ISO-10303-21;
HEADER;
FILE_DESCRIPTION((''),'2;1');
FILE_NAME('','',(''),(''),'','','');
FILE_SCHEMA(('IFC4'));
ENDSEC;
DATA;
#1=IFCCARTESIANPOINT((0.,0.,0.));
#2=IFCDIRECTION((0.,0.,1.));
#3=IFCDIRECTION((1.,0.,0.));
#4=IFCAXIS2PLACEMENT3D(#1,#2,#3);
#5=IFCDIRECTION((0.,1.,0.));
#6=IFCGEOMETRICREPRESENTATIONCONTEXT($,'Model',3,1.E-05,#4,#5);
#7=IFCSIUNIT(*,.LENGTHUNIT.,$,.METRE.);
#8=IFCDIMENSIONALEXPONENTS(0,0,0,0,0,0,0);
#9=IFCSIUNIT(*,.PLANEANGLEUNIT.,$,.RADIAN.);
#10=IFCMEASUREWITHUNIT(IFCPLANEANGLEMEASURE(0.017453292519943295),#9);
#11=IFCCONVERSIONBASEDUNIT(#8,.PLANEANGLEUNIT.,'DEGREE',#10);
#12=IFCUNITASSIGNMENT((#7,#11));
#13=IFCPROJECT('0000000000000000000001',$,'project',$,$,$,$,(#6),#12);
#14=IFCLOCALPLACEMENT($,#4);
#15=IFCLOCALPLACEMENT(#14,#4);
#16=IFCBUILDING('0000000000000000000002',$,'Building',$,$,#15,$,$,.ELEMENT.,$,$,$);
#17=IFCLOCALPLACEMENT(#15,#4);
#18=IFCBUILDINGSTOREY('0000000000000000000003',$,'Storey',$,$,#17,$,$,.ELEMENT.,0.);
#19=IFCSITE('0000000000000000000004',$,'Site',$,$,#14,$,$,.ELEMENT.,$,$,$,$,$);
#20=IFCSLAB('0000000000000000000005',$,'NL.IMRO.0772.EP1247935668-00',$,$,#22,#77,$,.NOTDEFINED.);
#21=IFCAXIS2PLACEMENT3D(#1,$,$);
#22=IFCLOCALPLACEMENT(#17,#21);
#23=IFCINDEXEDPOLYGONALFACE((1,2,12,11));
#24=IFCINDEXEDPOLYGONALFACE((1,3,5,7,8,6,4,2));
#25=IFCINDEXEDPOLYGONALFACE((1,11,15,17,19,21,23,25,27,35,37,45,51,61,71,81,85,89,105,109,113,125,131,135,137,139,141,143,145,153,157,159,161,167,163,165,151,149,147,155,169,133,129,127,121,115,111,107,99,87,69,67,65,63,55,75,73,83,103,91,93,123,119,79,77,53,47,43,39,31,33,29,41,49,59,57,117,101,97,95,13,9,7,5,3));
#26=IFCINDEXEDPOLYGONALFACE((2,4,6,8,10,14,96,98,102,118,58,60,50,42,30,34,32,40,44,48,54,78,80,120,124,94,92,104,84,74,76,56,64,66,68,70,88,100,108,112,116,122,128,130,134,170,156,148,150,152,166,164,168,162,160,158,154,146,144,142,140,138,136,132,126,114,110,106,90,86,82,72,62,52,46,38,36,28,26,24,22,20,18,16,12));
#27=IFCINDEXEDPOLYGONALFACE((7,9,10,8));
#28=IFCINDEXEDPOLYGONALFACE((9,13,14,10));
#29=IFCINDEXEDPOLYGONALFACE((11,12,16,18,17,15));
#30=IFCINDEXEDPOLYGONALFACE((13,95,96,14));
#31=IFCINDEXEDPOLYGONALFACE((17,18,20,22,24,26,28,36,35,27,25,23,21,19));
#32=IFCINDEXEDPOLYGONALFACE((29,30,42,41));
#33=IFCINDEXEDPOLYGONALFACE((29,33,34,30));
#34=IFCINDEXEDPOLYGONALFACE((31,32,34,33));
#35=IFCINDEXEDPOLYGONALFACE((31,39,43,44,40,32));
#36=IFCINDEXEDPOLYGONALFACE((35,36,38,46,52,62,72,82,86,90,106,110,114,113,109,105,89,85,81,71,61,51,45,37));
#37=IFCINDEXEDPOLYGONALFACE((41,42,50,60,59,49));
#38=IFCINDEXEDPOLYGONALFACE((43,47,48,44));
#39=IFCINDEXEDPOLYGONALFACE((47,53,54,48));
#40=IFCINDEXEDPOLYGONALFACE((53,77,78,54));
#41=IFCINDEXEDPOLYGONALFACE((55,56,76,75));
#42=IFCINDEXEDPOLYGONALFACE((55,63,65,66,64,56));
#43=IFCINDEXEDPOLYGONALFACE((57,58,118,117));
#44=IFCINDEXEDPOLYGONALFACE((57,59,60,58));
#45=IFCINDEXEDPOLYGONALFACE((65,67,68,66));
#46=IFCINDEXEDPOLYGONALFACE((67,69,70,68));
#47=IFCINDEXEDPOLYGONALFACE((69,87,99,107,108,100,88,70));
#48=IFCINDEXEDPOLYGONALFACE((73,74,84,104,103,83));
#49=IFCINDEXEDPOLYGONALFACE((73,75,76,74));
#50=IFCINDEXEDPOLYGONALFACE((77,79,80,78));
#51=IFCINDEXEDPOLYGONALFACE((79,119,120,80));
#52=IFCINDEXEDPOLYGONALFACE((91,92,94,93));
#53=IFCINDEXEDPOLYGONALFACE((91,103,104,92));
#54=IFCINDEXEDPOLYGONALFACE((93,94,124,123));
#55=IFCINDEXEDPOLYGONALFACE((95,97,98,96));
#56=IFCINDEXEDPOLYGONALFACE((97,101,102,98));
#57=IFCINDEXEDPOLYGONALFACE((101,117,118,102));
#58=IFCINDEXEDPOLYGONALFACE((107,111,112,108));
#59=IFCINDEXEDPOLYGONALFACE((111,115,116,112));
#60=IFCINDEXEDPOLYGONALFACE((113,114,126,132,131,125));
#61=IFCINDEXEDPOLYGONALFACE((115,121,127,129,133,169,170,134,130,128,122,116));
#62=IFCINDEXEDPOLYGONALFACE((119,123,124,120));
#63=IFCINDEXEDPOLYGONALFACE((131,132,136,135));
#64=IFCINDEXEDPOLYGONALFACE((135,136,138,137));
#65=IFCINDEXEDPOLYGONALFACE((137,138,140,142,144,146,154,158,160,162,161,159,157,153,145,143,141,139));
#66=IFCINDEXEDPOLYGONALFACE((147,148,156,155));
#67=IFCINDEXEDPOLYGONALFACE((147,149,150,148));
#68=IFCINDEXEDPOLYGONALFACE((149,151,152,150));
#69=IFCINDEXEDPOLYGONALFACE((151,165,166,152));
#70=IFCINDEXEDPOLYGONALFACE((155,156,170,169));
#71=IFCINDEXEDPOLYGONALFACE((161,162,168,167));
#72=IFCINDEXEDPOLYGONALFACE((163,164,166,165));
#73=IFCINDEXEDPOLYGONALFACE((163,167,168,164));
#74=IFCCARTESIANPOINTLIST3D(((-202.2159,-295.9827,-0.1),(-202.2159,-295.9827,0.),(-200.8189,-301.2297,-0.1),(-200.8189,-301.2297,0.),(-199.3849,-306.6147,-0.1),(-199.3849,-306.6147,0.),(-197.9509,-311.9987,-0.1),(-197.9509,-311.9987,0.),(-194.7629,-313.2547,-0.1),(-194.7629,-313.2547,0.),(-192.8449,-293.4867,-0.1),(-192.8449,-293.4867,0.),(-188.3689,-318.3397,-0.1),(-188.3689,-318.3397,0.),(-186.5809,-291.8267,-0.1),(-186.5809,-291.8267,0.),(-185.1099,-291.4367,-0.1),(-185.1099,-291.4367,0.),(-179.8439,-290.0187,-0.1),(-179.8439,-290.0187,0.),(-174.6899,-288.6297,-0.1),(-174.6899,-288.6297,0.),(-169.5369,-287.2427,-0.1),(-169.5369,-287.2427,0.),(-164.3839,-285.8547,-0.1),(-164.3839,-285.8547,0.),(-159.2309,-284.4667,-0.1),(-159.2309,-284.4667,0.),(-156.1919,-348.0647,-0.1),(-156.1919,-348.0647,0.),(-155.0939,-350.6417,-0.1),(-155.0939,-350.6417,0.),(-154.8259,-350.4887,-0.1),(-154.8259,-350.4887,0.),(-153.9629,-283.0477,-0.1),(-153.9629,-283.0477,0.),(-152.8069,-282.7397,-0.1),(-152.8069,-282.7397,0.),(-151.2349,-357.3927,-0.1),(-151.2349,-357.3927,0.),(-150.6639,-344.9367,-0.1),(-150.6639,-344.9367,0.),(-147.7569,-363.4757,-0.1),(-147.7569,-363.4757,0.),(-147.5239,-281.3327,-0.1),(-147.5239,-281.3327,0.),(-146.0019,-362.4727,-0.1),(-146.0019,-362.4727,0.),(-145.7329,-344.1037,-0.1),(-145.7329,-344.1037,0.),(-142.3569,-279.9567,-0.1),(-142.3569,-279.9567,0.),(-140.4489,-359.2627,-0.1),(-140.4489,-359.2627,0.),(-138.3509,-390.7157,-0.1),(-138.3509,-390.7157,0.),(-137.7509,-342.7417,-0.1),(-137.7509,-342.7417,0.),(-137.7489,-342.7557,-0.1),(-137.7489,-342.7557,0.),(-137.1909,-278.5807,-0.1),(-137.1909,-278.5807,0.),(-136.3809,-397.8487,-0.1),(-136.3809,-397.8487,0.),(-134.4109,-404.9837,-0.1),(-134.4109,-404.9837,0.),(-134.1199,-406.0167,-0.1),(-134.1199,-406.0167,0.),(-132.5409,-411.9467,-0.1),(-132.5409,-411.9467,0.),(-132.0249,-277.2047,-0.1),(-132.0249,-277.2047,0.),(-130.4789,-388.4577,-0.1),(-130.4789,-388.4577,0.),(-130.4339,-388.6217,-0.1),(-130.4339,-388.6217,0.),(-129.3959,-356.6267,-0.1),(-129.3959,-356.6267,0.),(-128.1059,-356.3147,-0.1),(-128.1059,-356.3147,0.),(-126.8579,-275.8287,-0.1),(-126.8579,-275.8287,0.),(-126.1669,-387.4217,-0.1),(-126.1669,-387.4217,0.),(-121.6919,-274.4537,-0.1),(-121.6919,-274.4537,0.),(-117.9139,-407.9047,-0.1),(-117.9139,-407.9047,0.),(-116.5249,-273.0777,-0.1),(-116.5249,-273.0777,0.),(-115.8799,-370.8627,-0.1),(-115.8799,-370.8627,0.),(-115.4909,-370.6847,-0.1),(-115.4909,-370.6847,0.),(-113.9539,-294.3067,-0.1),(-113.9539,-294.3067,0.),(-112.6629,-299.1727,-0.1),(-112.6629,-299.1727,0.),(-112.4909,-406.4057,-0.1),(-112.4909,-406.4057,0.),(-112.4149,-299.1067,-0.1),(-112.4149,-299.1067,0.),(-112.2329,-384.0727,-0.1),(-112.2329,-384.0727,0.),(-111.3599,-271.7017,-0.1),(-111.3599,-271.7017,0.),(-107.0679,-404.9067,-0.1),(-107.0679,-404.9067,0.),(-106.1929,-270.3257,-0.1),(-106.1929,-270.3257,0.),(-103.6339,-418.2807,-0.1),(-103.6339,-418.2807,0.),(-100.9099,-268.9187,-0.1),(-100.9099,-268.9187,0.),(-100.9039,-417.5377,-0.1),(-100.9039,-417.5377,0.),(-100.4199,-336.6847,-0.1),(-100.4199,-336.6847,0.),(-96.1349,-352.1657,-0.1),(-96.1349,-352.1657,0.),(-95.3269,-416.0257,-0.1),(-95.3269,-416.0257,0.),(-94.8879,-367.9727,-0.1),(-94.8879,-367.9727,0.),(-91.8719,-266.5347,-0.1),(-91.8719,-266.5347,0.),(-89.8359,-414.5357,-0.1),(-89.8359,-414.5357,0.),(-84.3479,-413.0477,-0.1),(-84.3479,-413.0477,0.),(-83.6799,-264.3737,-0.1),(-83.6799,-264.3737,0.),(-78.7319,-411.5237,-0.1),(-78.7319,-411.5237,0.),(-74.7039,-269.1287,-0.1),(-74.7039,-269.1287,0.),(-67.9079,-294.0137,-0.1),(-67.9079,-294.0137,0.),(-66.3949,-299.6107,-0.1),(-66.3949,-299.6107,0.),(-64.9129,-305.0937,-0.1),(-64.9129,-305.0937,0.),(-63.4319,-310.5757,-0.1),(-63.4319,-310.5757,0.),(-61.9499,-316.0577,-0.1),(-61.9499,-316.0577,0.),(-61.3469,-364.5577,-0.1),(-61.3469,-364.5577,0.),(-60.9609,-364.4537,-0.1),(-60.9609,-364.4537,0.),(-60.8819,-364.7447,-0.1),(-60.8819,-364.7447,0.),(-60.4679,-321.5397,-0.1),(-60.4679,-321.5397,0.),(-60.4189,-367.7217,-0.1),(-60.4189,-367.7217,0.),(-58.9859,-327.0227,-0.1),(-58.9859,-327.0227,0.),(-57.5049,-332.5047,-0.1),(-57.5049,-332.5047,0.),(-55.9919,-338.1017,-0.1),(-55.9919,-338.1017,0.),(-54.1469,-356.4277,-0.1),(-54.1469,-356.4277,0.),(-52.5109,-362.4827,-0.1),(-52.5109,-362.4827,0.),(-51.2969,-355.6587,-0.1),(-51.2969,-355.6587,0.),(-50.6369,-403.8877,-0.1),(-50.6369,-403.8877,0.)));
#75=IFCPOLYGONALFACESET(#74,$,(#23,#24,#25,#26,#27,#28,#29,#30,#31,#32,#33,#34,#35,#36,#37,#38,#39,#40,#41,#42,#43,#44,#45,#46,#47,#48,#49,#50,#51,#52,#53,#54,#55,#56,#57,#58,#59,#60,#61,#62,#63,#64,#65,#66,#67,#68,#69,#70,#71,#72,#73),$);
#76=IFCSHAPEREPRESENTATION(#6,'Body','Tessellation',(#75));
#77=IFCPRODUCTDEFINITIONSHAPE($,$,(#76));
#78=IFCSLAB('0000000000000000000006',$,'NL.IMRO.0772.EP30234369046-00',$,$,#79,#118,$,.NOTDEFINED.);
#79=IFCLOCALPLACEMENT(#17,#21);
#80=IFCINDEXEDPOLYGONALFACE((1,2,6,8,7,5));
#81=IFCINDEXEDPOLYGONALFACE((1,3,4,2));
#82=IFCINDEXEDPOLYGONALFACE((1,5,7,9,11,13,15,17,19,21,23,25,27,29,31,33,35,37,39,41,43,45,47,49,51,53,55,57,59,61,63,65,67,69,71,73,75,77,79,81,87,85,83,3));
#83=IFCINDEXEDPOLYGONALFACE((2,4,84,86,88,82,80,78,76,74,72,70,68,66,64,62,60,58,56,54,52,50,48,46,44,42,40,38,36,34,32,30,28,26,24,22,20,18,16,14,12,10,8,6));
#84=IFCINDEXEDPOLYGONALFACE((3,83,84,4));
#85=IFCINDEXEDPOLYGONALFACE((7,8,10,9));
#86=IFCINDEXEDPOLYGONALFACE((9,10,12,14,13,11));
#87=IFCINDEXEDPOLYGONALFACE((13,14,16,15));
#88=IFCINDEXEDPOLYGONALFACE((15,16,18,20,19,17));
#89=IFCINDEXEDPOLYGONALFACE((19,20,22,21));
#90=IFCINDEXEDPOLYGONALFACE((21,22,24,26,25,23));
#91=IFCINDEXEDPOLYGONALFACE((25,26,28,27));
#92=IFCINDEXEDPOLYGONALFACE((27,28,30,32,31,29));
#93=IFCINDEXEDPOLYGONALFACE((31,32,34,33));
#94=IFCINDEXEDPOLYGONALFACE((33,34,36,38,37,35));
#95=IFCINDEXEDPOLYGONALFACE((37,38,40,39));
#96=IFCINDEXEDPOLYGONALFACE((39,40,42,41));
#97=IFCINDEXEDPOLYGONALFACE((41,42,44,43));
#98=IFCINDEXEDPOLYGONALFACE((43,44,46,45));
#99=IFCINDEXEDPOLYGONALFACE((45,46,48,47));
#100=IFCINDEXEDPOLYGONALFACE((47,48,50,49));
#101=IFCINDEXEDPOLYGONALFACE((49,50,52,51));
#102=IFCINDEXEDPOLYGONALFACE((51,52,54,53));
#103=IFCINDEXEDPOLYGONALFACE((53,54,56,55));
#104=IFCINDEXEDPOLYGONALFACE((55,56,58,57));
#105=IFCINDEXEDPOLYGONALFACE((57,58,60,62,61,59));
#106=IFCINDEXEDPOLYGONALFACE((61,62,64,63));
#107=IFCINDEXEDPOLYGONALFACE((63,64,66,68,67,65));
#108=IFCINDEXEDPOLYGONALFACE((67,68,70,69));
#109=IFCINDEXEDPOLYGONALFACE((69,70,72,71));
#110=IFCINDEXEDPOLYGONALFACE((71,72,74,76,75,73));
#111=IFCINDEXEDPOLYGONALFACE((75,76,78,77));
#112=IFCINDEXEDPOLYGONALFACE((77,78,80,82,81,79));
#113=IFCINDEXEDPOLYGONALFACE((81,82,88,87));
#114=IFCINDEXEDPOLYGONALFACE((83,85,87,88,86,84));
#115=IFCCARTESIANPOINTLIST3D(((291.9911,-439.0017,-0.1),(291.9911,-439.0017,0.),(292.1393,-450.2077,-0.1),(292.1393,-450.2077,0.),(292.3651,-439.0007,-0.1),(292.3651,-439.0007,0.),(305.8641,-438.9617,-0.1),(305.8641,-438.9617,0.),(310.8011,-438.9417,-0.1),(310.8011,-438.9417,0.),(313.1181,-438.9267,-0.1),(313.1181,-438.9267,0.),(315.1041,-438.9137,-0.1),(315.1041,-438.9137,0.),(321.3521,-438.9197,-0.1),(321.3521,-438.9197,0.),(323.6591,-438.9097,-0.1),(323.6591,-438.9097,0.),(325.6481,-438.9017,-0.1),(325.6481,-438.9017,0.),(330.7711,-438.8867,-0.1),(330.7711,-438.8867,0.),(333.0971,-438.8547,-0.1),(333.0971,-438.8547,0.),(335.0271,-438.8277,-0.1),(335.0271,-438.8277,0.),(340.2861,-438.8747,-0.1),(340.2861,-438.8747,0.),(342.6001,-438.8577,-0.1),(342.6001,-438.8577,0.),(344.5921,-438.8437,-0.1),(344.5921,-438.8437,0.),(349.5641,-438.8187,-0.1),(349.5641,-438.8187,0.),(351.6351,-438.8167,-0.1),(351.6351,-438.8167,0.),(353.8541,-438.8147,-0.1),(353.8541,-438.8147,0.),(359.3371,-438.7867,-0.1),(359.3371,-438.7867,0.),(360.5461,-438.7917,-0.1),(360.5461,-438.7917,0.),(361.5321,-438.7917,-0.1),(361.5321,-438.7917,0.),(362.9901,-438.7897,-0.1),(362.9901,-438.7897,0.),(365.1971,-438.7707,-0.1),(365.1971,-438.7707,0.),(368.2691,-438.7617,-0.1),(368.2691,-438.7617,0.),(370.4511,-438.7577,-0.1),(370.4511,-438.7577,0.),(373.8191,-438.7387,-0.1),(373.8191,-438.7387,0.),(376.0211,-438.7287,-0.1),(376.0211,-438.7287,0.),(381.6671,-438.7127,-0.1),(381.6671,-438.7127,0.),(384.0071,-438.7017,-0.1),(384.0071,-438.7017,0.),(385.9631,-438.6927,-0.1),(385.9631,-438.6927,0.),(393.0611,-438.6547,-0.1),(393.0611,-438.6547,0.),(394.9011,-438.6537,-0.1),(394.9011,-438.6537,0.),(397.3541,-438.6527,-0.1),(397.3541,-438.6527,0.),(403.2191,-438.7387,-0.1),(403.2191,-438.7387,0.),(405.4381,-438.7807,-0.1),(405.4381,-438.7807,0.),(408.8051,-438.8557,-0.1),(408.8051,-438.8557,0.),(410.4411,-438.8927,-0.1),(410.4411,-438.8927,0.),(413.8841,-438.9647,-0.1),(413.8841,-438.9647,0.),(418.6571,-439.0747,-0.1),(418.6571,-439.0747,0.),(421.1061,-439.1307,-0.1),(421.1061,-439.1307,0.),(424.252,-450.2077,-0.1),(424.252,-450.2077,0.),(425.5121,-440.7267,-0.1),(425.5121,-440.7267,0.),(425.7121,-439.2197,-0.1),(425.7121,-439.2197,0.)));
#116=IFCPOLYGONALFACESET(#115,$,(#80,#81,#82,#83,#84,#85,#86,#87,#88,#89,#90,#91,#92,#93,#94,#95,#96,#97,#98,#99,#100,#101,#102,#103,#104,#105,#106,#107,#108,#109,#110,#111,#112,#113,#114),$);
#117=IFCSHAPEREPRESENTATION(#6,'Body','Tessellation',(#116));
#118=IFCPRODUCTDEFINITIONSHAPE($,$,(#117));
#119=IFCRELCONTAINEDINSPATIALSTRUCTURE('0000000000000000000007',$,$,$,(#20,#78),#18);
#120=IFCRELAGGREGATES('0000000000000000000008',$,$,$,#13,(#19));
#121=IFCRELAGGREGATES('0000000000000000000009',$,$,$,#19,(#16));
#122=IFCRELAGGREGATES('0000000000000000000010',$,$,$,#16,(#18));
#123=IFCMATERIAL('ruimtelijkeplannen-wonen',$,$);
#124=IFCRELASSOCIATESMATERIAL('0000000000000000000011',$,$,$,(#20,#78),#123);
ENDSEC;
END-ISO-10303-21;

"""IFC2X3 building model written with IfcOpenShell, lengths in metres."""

from ifc_helpers import new_model, entity, si_unit, converted_unit, direction, frame, origin_with_axes, place, context, project, spatial, polyline, outline, extrude, material, element, save


model = new_model("IFC2X3")

# Units and contexts
model_context = context("Model", 3, precision=1e-05, world=origin_with_axes(), true_north=direction((0.0, 1.0, 0.0)))
ifc_project = project(units=[si_unit("LENGTHUNIT", "METRE"), converted_unit("PLANEANGLEUNIT", "DEGREE", entity("IfcPlaneAngleMeasure", 0.017453292519943295), si_unit("PLANEANGLEUNIT", "RADIAN"), dimensions=[0, 0, 0, 0, 0, 0, 0])], contexts=[model_context])

# Site, building, storey
site_placement = place(None, origin_with_axes())
site = spatial("IfcSite", under=ifc_project, at=site_placement, Name="Site", CompositionType="ELEMENT")
building_placement = place(site_placement, origin_with_axes())
building = spatial("IfcBuilding", under=site, at=building_placement, Name="Building", CompositionType="ELEMENT")
storey_placement = place(building_placement, origin_with_axes())
storey = spatial("IfcBuildingStorey", under=building, at=storey_placement, Name="Storey", CompositionType="ELEMENT", Elevation=0.0)

# Slabs
ifc_material_1 = material(Name="ruimtelijkeplannen-wonen")
slab_1_placement = place(storey_placement, frame((0.0, 0.0, -0.1), z_axis=(0.0, 0.0, 1.0), x_axis=(1.0, 0.0, 0.0)))
element("IfcSlab", 1, at=slab_1_placement, inside=storey, material=ifc_material_1, Name="NL.IMRO.0772.EP1247935668-00", PredefinedType="NOTDEFINED", context=model_context, shape_type="SweptSolid", body=[
    extrude(outline(polyline([(-132.5409, -411.9467), (-134.1199, -406.0167), (-134.4109, -404.9837), (-136.3809, -397.8487), (-138.3509, -390.7157), (-130.4339, -388.6217), (-130.4789, -388.4577), (-126.1669, -387.4217), (-112.2329, -384.0727), (-115.8799, -370.8627), (-115.4909, -370.6847), (-94.8879, -367.9727), (-96.1349, -352.1657), (-128.1059, -356.3147), (-129.3959, -356.6267), (-140.4489, -359.2627), (-146.0019, -362.4727), (-147.7569, -363.4757), (-151.2349, -357.3927), (-155.0939, -350.6417), (-154.8259, -350.4887), (-156.1919, -348.0647), (-150.6639, -344.9367), (-145.7329, -344.1037), (-137.7489, -342.7557), (-137.7509, -342.7417), (-100.4199, -336.6847), (-112.4149, -299.1067), (-112.6629, -299.1727), (-113.9539, -294.3067), (-188.3689, -318.3397), (-194.7629, -313.2547), (-197.9509, -311.9987), (-199.3849, -306.6147), (-200.8189, -301.2297), (-202.2159, -295.9827), (-192.8449, -293.4867), (-186.5809, -291.8267), (-185.1099, -291.4367), (-179.8439, -290.0187), (-174.6899, -288.6297), (-169.5369, -287.2427), (-164.3839, -285.8547), (-159.2309, -284.4667), (-153.9629, -283.0477), (-152.8069, -282.7397), (-147.5239, -281.3327), (-142.3569, -279.9567), (-137.1909, -278.5807), (-132.0249, -277.2047), (-126.8579, -275.8287), (-121.6919, -274.4537), (-116.5249, -273.0777), (-111.3599, -271.7017), (-106.1929, -270.3257), (-100.9099, -268.9187), (-91.8719, -266.5347), (-83.6799, -264.3737), (-74.7039, -269.1287), (-67.9079, -294.0137), (-66.3949, -299.6107), (-64.9129, -305.0937), (-63.4319, -310.5757), (-61.9499, -316.0577), (-60.4679, -321.5397), (-58.9859, -327.0227), (-57.5049, -332.5047), (-55.9919, -338.1017), (-51.2969, -355.6587), (-54.1469, -356.4277), (-52.5109, -362.4827), (-60.8819, -364.7447), (-60.9609, -364.4537), (-61.3469, -364.5577), (-60.4189, -367.7217), (-50.6369, -403.8877), (-78.7319, -411.5237), (-84.3479, -413.0477), (-89.8359, -414.5357), (-95.3269, -416.0257), (-100.9039, -417.5377), (-103.6339, -418.2807), (-107.0679, -404.9067), (-112.4909, -406.4057), (-117.9139, -407.9047), (-132.5409, -411.9467)])), origin_with_axes(), (0.0, 0.0, 1.0), 0.1),
])
slab_2_placement = place(storey_placement, frame((0.0, 0.0, -0.1), z_axis=(0.0, 0.0, 1.0), x_axis=(1.0, 0.0, 0.0)))
element("IfcSlab", 2, at=slab_2_placement, inside=storey, material=ifc_material_1, Name="NL.IMRO.0772.EP30234369046-00", PredefinedType="NOTDEFINED", context=model_context, shape_type="SweptSolid", body=[
    extrude(outline(polyline([(291.9911, -439.0017), (292.3651, -439.0007), (305.8641, -438.9617), (310.8011, -438.9417), (313.1181, -438.9267), (315.1041, -438.9137), (321.3521, -438.9197), (323.6591, -438.9097), (325.6481, -438.9017), (330.7711, -438.8867), (333.0971, -438.8547), (335.0271, -438.8277), (340.2861, -438.8747), (342.6001, -438.8577), (344.5921, -438.8437), (349.5641, -438.8187), (351.6351, -438.8167), (353.8541, -438.8147), (359.3371, -438.7867), (360.5461, -438.7917), (361.5321, -438.7917), (362.9901, -438.7897), (365.1971, -438.7707), (368.2691, -438.7617), (370.4511, -438.7577), (373.8191, -438.7387), (376.0211, -438.7287), (381.6671, -438.7127), (384.0071, -438.7017), (385.9631, -438.6927), (393.0611, -438.6547), (394.9011, -438.6537), (397.3541, -438.6527), (403.2191, -438.7387), (405.4381, -438.7807), (408.8051, -438.8557), (410.4411, -438.8927), (413.8841, -438.9647), (418.6571, -439.0747), (421.1061, -439.1307), (425.7121, -439.2197), (425.5121, -440.7267), (424.252, -450.2077), (292.1393, -450.2077), (291.9911, -439.0017)])), origin_with_axes(), (0.0, 0.0, 1.0), 0.1),
])

save(model, "model.ifc")
